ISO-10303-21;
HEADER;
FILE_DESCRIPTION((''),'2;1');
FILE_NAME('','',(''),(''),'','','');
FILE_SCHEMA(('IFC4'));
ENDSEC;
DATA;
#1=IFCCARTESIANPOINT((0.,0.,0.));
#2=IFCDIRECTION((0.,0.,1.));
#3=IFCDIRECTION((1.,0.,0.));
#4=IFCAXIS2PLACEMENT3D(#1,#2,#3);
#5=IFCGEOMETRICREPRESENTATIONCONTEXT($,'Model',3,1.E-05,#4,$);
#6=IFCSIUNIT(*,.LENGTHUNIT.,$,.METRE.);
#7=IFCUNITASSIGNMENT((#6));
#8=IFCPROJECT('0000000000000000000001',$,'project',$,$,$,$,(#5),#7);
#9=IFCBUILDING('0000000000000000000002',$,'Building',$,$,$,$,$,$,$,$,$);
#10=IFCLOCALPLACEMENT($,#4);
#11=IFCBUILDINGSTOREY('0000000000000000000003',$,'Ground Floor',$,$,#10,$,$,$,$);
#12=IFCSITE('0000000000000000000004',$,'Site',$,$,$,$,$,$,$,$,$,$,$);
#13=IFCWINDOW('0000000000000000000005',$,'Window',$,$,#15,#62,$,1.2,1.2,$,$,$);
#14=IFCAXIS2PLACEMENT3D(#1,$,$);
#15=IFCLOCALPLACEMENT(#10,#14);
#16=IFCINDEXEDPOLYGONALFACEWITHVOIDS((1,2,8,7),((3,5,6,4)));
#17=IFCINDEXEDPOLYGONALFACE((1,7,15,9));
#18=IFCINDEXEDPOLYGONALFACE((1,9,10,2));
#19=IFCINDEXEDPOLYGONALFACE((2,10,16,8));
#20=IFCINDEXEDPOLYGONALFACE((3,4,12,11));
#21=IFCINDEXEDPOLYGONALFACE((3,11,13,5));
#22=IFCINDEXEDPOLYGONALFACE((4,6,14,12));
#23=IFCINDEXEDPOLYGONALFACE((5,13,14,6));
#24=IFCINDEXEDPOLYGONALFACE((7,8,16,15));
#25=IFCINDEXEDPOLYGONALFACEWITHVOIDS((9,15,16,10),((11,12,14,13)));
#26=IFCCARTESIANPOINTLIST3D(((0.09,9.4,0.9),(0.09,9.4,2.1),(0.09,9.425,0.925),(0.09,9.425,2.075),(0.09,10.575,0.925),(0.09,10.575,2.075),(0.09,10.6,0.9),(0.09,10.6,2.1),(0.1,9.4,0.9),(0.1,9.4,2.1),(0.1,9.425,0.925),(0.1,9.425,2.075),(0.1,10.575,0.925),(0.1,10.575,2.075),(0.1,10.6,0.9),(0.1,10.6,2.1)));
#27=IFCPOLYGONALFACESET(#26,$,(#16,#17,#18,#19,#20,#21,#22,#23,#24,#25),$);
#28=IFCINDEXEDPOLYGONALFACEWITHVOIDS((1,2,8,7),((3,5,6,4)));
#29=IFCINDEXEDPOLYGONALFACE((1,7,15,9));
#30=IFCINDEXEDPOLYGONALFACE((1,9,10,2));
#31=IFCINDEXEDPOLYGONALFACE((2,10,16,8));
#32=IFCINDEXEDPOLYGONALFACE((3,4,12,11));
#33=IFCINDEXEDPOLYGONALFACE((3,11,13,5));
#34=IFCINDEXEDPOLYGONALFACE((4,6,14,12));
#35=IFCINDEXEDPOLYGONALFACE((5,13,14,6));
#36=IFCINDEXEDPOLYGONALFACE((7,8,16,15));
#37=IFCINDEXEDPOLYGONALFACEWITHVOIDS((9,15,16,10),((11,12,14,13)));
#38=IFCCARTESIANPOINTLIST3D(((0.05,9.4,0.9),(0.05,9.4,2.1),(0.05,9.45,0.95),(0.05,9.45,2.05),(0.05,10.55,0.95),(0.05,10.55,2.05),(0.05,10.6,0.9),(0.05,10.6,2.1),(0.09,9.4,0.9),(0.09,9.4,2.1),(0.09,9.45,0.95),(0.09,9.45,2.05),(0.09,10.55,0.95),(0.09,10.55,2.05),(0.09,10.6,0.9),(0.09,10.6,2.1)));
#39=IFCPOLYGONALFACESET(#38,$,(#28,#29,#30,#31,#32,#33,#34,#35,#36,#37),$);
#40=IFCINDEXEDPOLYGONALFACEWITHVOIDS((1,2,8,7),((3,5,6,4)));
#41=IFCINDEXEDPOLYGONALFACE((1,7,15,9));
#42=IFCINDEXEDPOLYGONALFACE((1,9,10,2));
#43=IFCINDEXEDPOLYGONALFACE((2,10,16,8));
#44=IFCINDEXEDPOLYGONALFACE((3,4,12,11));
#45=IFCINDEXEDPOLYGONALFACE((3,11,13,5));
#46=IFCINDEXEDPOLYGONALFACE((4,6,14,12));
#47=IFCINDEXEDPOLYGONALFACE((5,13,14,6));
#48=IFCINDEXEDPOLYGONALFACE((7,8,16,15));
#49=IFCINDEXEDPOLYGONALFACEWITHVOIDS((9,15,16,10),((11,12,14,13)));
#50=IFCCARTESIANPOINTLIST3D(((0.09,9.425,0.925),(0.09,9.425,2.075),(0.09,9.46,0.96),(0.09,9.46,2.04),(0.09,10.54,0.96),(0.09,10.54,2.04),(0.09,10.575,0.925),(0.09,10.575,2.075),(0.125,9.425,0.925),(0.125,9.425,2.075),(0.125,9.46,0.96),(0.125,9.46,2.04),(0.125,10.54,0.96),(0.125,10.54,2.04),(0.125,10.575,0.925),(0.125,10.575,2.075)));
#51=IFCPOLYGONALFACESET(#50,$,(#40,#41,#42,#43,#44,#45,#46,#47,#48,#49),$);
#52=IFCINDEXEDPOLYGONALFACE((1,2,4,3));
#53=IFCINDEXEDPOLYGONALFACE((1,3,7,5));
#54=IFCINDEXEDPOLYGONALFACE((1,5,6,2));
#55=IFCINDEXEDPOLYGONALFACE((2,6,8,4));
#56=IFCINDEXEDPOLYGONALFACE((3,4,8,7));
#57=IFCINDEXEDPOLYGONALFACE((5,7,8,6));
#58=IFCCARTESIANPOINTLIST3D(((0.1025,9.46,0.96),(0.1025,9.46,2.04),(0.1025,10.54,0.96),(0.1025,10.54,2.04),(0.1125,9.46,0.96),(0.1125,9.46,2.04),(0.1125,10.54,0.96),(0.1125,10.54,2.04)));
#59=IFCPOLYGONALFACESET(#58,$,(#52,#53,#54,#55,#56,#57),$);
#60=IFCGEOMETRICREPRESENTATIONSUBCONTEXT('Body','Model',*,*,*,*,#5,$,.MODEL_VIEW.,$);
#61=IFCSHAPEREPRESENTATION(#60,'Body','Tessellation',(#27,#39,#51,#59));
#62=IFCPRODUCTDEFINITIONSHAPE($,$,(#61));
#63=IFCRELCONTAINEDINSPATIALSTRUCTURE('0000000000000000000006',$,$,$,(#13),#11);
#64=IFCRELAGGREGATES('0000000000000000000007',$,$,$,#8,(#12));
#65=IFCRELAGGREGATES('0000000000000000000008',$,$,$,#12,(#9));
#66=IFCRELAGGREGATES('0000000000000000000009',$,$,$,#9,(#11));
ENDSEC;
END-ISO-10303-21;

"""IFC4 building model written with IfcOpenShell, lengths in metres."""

from ifc_helpers import new_model, si_unit, frame, origin_with_axes, place, context, subcontext, project, spatial, line, indexed_curve, outline, extrude, element, save


model = new_model("IFC4")

# Units and contexts
model_context = context("Model", 3, precision=1e-05, world=origin_with_axes())
body_context = subcontext(model_context, "Body", "Model", "MODEL_VIEW")
ifc_project = project(units=[si_unit("LENGTHUNIT", "METRE")], contexts=[model_context])

# Site, building, storey
site = spatial("IfcSite", under=ifc_project, Name="Site")
building = spatial("IfcBuilding", under=site, Name="Building")
storey_placement = place(None, origin_with_axes())
storey = spatial("IfcBuildingStorey", under=building, at=storey_placement, Name="Ground Floor")

# Window
window_1_placement = place(storey_placement, frame((0.0, 10.6, 0.9), z_axis=(0.0, 0.0, 1.0), x_axis=(0.0, -1.0, 0.0)))
element("IfcWindow", 1, at=window_1_placement, inside=storey, Name="Window", OverallHeight=1.2, OverallWidth=1.2, context=body_context, shape_type="SweptSolid", body=[
    extrude(outline(indexed_curve([(0.0, 0.0), (1.2, 0.0), (1.2, 1.2), (0.0, 1.2)], segments=[line(1, 2, 3, 4, 1)]), holes=[indexed_curve([(0.025, 0.025), (1.175, 0.025), (1.175, 1.175), (0.025, 1.175)], segments=[line(1, 2, 3, 4, 1)])]), frame((0.0, 0.09, 0.0), z_axis=(0.0, -1.0, 0.0), x_axis=(1.0, 0.0, 0.0)), (0.0, 0.0, -1.0), 0.01),
    extrude(outline(indexed_curve([(0.0, 0.0), (1.2, 0.0), (1.2, 1.2), (0.0, 1.2)], segments=[line(1, 2, 3, 4, 1)]), holes=[indexed_curve([(0.05, 0.05), (1.15, 0.05), (1.15, 1.15), (0.05, 1.15)], segments=[line(1, 2, 3, 4, 1)])]), frame((0.0, 0.05, 0.0), z_axis=(0.0, -1.0, 0.0), x_axis=(1.0, 0.0, 0.0)), (0.0, 0.0, -1.0), 0.04),
    extrude(outline(indexed_curve([(0.0, 0.0), (1.15, 0.0), (1.15, 1.15), (0.0, 1.15)], segments=[line(1, 2, 3, 4, 1)]), holes=[indexed_curve([(0.035, 0.035), (1.115, 0.035), (1.115, 1.115), (0.035, 1.115)], segments=[line(1, 2, 3, 4, 1)])]), frame((0.025, 0.09, 0.025), z_axis=(0.0, -1.0, 0.0), x_axis=(1.0, 0.0, 0.0)), (0.0, 0.0, -1.0), 0.035),
    extrude(outline(indexed_curve([(0.035, 0.035), (1.115, 0.035), (1.115, 1.115), (0.035, 1.115)], segments=[line(1, 2, 3, 4, 1)])), frame((0.025, 0.1025, 0.025), z_axis=(0.0, -1.0, 0.0), x_axis=(1.0, 0.0, 0.0)), (0.0, 0.0, -1.0), 0.01),
])

save(model, "model.ifc")
